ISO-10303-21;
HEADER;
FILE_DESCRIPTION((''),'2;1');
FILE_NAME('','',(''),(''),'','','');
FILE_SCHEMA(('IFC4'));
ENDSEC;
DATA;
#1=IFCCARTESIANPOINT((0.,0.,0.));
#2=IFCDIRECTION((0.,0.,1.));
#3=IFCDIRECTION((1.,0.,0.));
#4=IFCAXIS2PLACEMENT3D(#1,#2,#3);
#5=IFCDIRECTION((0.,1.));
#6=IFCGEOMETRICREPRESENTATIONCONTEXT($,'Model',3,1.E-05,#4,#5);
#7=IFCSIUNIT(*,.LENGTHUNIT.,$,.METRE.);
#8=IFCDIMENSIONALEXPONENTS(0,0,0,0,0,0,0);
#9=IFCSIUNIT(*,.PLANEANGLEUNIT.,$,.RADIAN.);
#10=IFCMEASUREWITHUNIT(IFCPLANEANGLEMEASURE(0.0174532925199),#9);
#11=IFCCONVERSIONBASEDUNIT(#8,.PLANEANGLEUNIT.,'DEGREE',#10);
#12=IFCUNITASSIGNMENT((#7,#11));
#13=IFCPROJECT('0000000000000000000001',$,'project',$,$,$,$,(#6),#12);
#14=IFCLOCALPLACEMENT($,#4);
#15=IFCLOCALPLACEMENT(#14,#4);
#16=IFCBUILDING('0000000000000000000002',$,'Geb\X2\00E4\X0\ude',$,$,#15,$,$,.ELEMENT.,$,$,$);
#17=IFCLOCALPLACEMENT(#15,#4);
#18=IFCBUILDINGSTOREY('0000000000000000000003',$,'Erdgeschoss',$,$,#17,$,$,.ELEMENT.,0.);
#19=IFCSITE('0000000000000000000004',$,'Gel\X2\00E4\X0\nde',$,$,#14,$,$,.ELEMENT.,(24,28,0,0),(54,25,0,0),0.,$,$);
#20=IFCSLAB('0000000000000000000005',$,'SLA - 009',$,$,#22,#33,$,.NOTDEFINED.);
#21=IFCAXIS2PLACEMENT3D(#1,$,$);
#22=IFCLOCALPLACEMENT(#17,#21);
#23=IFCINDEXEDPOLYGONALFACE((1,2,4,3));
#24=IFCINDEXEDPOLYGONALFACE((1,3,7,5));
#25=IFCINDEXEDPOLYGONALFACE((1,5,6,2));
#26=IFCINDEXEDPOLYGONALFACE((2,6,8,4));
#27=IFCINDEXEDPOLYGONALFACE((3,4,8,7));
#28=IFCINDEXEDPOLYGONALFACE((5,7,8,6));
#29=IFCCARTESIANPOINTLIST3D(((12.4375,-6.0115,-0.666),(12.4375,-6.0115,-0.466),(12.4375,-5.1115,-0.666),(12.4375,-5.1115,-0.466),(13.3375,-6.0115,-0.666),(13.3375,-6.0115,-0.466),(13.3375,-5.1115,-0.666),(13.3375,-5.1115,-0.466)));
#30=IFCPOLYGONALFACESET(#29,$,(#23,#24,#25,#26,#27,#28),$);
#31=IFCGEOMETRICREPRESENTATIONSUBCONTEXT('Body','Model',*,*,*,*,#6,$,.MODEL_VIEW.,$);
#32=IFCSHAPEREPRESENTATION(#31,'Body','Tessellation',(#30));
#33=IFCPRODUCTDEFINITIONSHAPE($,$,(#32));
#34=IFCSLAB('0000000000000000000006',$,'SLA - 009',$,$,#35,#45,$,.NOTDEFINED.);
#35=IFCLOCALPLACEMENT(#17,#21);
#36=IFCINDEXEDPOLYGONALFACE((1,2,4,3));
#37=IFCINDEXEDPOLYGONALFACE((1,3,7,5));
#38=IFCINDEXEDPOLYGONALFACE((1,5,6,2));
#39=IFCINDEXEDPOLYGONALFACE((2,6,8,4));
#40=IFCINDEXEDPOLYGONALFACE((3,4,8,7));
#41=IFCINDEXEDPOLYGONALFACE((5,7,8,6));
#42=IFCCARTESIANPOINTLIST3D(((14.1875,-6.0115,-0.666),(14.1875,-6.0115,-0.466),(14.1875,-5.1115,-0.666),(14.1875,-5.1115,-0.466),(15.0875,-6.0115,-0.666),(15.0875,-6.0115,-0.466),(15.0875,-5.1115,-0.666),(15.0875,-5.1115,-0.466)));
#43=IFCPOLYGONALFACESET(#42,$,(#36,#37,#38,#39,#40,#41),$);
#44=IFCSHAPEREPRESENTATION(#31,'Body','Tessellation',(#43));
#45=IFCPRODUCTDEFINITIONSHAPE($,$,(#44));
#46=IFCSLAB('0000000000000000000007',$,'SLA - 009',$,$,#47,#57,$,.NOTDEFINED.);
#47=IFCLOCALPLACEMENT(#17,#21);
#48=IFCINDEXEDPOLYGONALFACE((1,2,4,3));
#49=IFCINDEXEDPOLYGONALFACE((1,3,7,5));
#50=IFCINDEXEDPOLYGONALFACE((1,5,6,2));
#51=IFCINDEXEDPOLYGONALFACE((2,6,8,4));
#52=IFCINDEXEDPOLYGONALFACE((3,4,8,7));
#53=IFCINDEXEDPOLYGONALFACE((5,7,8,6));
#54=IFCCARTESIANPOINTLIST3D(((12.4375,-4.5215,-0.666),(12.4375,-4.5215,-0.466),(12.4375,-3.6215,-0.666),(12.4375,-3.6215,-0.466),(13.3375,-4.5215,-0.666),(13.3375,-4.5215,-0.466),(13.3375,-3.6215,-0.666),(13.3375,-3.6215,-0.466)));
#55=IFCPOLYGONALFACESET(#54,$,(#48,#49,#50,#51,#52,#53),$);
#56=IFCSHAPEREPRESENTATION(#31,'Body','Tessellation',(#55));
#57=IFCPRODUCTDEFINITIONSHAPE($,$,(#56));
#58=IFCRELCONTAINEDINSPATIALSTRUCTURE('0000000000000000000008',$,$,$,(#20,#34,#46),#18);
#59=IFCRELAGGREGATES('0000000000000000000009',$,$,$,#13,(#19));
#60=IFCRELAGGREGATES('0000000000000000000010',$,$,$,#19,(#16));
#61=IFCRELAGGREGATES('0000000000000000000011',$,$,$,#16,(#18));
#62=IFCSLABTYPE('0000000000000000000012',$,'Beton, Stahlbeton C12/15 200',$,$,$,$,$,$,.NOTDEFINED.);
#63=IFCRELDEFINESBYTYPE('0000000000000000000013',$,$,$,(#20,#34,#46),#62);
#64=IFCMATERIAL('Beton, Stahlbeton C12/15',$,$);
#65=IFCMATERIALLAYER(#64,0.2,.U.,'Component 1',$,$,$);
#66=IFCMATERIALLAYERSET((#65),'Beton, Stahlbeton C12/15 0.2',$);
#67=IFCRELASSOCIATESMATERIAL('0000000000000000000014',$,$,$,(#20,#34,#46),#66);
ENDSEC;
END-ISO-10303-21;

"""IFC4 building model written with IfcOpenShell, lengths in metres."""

from ifc_helpers import new_model, entity, si_unit, converted_unit, direction, frame, origin_with_axes, place, context, subcontext, project, spatial, line, indexed_curve, outline, extrude, material, layer, layer_set, layer_usage, type_object, element, save


model = new_model("IFC4")

# Units and contexts
model_context = context("Model", 3, precision=1e-05, world=origin_with_axes(), true_north=direction((0.0, 1.0)))
body_context = subcontext(model_context, "Body", "Model", "MODEL_VIEW")
ifc_project = project(units=[si_unit("LENGTHUNIT", "METRE"), converted_unit("PLANEANGLEUNIT", "DEGREE", entity("IfcPlaneAngleMeasure", 0.0174532925199), si_unit("PLANEANGLEUNIT", "RADIAN"), dimensions=[0, 0, 0, 0, 0, 0, 0])], contexts=[model_context])

# Site, building, storey
site_placement = place(None, origin_with_axes())
site = spatial("IfcSite", under=ifc_project, at=site_placement, Name="Gelände", CompositionType="ELEMENT", RefLatitude=(24, 28, 0, 0), RefLongitude=(54, 25, 0, 0), RefElevation=0.0)
building_placement = place(site_placement, origin_with_axes())
building = spatial("IfcBuilding", under=site, at=building_placement, Name="Gebäude", CompositionType="ELEMENT")
storey_placement = place(building_placement, origin_with_axes())
storey = spatial("IfcBuildingStorey", under=building, at=storey_placement, Name="Erdgeschoss", CompositionType="ELEMENT", Elevation=0.0)

# Slabs
ifc_material_1 = material(Name="Beton, Stahlbeton C12/15")
ifc_layer = layer(ifc_material_1, 0.2, ventilated="UNKNOWN", Name="Component 1")
ifc_layer_set = layer_set([ifc_layer], Name="Beton, Stahlbeton C12/15 0.2")
ifc_layer_usage_1 = layer_usage(ifc_layer_set, "AXIS3", "NEGATIVE", 0.2)
slab_type = type_object("IfcSlabType", Name="Beton, Stahlbeton C12/15 200", PredefinedType="NOTDEFINED")
slab_1_placement = place(storey_placement, frame((12.4375, -6.0115, -0.466), z_axis=(0.0, 0.0, 1.0), x_axis=(1.0, 0.0, 0.0)))
element("IfcSlab", 1, at=slab_1_placement, inside=storey, type_object=slab_type, material=ifc_layer_usage_1, Name="SLA - 009", PredefinedType="NOTDEFINED", context=body_context, shape_type="SweptSolid", body=[
    extrude(outline(indexed_curve([(0.0, 0.0), (0.9, 0.0), (0.9, 0.9), (0.0, 0.9)], segments=[line(1, 2, 3, 4, 1)])), frame((0.0, 0.0, -0.2), z_axis=(0.0, 0.0, 1.0), x_axis=(1.0, 0.0, 0.0)), (0.0, 0.0, 1.0), 0.2),
])
ifc_layer_usage_2 = layer_usage(ifc_layer_set, "AXIS3", "NEGATIVE", 0.2)
slab_2_placement = place(storey_placement, frame((14.1875, -6.0115, -0.466), z_axis=(0.0, 0.0, 1.0), x_axis=(1.0, 0.0, 0.0)))
element("IfcSlab", 2, at=slab_2_placement, inside=storey, type_object=slab_type, material=ifc_layer_usage_2, Name="SLA - 009", PredefinedType="NOTDEFINED", context=body_context, shape_type="SweptSolid", body=[
    extrude(outline(indexed_curve([(0.0, 0.0), (0.9, 0.0), (0.9, 0.9), (0.0, 0.9)], segments=[line(1, 2, 3, 4, 1)])), frame((0.0, 0.0, -0.2), z_axis=(0.0, 0.0, 1.0), x_axis=(1.0, 0.0, 0.0)), (0.0, 0.0, 1.0), 0.2),
])
ifc_layer_usage_3 = layer_usage(ifc_layer_set, "AXIS3", "NEGATIVE", 0.2)
slab_3_placement = place(storey_placement, frame((12.4375, -4.5215, -0.466), z_axis=(0.0, 0.0, 1.0), x_axis=(1.0, 0.0, 0.0)))
element("IfcSlab", 3, at=slab_3_placement, inside=storey, type_object=slab_type, material=ifc_layer_usage_3, Name="SLA - 009", PredefinedType="NOTDEFINED", context=body_context, shape_type="SweptSolid", body=[
    extrude(outline(indexed_curve([(0.0, 0.0), (0.9, 0.0), (0.9, 0.9), (0.0, 0.9)], segments=[line(1, 2, 3, 4, 1)])), frame((0.0, 0.0, -0.2), z_axis=(0.0, 0.0, 1.0), x_axis=(1.0, 0.0, 0.0)), (0.0, 0.0, 1.0), 0.2),
])

save(model, "model.ifc")
